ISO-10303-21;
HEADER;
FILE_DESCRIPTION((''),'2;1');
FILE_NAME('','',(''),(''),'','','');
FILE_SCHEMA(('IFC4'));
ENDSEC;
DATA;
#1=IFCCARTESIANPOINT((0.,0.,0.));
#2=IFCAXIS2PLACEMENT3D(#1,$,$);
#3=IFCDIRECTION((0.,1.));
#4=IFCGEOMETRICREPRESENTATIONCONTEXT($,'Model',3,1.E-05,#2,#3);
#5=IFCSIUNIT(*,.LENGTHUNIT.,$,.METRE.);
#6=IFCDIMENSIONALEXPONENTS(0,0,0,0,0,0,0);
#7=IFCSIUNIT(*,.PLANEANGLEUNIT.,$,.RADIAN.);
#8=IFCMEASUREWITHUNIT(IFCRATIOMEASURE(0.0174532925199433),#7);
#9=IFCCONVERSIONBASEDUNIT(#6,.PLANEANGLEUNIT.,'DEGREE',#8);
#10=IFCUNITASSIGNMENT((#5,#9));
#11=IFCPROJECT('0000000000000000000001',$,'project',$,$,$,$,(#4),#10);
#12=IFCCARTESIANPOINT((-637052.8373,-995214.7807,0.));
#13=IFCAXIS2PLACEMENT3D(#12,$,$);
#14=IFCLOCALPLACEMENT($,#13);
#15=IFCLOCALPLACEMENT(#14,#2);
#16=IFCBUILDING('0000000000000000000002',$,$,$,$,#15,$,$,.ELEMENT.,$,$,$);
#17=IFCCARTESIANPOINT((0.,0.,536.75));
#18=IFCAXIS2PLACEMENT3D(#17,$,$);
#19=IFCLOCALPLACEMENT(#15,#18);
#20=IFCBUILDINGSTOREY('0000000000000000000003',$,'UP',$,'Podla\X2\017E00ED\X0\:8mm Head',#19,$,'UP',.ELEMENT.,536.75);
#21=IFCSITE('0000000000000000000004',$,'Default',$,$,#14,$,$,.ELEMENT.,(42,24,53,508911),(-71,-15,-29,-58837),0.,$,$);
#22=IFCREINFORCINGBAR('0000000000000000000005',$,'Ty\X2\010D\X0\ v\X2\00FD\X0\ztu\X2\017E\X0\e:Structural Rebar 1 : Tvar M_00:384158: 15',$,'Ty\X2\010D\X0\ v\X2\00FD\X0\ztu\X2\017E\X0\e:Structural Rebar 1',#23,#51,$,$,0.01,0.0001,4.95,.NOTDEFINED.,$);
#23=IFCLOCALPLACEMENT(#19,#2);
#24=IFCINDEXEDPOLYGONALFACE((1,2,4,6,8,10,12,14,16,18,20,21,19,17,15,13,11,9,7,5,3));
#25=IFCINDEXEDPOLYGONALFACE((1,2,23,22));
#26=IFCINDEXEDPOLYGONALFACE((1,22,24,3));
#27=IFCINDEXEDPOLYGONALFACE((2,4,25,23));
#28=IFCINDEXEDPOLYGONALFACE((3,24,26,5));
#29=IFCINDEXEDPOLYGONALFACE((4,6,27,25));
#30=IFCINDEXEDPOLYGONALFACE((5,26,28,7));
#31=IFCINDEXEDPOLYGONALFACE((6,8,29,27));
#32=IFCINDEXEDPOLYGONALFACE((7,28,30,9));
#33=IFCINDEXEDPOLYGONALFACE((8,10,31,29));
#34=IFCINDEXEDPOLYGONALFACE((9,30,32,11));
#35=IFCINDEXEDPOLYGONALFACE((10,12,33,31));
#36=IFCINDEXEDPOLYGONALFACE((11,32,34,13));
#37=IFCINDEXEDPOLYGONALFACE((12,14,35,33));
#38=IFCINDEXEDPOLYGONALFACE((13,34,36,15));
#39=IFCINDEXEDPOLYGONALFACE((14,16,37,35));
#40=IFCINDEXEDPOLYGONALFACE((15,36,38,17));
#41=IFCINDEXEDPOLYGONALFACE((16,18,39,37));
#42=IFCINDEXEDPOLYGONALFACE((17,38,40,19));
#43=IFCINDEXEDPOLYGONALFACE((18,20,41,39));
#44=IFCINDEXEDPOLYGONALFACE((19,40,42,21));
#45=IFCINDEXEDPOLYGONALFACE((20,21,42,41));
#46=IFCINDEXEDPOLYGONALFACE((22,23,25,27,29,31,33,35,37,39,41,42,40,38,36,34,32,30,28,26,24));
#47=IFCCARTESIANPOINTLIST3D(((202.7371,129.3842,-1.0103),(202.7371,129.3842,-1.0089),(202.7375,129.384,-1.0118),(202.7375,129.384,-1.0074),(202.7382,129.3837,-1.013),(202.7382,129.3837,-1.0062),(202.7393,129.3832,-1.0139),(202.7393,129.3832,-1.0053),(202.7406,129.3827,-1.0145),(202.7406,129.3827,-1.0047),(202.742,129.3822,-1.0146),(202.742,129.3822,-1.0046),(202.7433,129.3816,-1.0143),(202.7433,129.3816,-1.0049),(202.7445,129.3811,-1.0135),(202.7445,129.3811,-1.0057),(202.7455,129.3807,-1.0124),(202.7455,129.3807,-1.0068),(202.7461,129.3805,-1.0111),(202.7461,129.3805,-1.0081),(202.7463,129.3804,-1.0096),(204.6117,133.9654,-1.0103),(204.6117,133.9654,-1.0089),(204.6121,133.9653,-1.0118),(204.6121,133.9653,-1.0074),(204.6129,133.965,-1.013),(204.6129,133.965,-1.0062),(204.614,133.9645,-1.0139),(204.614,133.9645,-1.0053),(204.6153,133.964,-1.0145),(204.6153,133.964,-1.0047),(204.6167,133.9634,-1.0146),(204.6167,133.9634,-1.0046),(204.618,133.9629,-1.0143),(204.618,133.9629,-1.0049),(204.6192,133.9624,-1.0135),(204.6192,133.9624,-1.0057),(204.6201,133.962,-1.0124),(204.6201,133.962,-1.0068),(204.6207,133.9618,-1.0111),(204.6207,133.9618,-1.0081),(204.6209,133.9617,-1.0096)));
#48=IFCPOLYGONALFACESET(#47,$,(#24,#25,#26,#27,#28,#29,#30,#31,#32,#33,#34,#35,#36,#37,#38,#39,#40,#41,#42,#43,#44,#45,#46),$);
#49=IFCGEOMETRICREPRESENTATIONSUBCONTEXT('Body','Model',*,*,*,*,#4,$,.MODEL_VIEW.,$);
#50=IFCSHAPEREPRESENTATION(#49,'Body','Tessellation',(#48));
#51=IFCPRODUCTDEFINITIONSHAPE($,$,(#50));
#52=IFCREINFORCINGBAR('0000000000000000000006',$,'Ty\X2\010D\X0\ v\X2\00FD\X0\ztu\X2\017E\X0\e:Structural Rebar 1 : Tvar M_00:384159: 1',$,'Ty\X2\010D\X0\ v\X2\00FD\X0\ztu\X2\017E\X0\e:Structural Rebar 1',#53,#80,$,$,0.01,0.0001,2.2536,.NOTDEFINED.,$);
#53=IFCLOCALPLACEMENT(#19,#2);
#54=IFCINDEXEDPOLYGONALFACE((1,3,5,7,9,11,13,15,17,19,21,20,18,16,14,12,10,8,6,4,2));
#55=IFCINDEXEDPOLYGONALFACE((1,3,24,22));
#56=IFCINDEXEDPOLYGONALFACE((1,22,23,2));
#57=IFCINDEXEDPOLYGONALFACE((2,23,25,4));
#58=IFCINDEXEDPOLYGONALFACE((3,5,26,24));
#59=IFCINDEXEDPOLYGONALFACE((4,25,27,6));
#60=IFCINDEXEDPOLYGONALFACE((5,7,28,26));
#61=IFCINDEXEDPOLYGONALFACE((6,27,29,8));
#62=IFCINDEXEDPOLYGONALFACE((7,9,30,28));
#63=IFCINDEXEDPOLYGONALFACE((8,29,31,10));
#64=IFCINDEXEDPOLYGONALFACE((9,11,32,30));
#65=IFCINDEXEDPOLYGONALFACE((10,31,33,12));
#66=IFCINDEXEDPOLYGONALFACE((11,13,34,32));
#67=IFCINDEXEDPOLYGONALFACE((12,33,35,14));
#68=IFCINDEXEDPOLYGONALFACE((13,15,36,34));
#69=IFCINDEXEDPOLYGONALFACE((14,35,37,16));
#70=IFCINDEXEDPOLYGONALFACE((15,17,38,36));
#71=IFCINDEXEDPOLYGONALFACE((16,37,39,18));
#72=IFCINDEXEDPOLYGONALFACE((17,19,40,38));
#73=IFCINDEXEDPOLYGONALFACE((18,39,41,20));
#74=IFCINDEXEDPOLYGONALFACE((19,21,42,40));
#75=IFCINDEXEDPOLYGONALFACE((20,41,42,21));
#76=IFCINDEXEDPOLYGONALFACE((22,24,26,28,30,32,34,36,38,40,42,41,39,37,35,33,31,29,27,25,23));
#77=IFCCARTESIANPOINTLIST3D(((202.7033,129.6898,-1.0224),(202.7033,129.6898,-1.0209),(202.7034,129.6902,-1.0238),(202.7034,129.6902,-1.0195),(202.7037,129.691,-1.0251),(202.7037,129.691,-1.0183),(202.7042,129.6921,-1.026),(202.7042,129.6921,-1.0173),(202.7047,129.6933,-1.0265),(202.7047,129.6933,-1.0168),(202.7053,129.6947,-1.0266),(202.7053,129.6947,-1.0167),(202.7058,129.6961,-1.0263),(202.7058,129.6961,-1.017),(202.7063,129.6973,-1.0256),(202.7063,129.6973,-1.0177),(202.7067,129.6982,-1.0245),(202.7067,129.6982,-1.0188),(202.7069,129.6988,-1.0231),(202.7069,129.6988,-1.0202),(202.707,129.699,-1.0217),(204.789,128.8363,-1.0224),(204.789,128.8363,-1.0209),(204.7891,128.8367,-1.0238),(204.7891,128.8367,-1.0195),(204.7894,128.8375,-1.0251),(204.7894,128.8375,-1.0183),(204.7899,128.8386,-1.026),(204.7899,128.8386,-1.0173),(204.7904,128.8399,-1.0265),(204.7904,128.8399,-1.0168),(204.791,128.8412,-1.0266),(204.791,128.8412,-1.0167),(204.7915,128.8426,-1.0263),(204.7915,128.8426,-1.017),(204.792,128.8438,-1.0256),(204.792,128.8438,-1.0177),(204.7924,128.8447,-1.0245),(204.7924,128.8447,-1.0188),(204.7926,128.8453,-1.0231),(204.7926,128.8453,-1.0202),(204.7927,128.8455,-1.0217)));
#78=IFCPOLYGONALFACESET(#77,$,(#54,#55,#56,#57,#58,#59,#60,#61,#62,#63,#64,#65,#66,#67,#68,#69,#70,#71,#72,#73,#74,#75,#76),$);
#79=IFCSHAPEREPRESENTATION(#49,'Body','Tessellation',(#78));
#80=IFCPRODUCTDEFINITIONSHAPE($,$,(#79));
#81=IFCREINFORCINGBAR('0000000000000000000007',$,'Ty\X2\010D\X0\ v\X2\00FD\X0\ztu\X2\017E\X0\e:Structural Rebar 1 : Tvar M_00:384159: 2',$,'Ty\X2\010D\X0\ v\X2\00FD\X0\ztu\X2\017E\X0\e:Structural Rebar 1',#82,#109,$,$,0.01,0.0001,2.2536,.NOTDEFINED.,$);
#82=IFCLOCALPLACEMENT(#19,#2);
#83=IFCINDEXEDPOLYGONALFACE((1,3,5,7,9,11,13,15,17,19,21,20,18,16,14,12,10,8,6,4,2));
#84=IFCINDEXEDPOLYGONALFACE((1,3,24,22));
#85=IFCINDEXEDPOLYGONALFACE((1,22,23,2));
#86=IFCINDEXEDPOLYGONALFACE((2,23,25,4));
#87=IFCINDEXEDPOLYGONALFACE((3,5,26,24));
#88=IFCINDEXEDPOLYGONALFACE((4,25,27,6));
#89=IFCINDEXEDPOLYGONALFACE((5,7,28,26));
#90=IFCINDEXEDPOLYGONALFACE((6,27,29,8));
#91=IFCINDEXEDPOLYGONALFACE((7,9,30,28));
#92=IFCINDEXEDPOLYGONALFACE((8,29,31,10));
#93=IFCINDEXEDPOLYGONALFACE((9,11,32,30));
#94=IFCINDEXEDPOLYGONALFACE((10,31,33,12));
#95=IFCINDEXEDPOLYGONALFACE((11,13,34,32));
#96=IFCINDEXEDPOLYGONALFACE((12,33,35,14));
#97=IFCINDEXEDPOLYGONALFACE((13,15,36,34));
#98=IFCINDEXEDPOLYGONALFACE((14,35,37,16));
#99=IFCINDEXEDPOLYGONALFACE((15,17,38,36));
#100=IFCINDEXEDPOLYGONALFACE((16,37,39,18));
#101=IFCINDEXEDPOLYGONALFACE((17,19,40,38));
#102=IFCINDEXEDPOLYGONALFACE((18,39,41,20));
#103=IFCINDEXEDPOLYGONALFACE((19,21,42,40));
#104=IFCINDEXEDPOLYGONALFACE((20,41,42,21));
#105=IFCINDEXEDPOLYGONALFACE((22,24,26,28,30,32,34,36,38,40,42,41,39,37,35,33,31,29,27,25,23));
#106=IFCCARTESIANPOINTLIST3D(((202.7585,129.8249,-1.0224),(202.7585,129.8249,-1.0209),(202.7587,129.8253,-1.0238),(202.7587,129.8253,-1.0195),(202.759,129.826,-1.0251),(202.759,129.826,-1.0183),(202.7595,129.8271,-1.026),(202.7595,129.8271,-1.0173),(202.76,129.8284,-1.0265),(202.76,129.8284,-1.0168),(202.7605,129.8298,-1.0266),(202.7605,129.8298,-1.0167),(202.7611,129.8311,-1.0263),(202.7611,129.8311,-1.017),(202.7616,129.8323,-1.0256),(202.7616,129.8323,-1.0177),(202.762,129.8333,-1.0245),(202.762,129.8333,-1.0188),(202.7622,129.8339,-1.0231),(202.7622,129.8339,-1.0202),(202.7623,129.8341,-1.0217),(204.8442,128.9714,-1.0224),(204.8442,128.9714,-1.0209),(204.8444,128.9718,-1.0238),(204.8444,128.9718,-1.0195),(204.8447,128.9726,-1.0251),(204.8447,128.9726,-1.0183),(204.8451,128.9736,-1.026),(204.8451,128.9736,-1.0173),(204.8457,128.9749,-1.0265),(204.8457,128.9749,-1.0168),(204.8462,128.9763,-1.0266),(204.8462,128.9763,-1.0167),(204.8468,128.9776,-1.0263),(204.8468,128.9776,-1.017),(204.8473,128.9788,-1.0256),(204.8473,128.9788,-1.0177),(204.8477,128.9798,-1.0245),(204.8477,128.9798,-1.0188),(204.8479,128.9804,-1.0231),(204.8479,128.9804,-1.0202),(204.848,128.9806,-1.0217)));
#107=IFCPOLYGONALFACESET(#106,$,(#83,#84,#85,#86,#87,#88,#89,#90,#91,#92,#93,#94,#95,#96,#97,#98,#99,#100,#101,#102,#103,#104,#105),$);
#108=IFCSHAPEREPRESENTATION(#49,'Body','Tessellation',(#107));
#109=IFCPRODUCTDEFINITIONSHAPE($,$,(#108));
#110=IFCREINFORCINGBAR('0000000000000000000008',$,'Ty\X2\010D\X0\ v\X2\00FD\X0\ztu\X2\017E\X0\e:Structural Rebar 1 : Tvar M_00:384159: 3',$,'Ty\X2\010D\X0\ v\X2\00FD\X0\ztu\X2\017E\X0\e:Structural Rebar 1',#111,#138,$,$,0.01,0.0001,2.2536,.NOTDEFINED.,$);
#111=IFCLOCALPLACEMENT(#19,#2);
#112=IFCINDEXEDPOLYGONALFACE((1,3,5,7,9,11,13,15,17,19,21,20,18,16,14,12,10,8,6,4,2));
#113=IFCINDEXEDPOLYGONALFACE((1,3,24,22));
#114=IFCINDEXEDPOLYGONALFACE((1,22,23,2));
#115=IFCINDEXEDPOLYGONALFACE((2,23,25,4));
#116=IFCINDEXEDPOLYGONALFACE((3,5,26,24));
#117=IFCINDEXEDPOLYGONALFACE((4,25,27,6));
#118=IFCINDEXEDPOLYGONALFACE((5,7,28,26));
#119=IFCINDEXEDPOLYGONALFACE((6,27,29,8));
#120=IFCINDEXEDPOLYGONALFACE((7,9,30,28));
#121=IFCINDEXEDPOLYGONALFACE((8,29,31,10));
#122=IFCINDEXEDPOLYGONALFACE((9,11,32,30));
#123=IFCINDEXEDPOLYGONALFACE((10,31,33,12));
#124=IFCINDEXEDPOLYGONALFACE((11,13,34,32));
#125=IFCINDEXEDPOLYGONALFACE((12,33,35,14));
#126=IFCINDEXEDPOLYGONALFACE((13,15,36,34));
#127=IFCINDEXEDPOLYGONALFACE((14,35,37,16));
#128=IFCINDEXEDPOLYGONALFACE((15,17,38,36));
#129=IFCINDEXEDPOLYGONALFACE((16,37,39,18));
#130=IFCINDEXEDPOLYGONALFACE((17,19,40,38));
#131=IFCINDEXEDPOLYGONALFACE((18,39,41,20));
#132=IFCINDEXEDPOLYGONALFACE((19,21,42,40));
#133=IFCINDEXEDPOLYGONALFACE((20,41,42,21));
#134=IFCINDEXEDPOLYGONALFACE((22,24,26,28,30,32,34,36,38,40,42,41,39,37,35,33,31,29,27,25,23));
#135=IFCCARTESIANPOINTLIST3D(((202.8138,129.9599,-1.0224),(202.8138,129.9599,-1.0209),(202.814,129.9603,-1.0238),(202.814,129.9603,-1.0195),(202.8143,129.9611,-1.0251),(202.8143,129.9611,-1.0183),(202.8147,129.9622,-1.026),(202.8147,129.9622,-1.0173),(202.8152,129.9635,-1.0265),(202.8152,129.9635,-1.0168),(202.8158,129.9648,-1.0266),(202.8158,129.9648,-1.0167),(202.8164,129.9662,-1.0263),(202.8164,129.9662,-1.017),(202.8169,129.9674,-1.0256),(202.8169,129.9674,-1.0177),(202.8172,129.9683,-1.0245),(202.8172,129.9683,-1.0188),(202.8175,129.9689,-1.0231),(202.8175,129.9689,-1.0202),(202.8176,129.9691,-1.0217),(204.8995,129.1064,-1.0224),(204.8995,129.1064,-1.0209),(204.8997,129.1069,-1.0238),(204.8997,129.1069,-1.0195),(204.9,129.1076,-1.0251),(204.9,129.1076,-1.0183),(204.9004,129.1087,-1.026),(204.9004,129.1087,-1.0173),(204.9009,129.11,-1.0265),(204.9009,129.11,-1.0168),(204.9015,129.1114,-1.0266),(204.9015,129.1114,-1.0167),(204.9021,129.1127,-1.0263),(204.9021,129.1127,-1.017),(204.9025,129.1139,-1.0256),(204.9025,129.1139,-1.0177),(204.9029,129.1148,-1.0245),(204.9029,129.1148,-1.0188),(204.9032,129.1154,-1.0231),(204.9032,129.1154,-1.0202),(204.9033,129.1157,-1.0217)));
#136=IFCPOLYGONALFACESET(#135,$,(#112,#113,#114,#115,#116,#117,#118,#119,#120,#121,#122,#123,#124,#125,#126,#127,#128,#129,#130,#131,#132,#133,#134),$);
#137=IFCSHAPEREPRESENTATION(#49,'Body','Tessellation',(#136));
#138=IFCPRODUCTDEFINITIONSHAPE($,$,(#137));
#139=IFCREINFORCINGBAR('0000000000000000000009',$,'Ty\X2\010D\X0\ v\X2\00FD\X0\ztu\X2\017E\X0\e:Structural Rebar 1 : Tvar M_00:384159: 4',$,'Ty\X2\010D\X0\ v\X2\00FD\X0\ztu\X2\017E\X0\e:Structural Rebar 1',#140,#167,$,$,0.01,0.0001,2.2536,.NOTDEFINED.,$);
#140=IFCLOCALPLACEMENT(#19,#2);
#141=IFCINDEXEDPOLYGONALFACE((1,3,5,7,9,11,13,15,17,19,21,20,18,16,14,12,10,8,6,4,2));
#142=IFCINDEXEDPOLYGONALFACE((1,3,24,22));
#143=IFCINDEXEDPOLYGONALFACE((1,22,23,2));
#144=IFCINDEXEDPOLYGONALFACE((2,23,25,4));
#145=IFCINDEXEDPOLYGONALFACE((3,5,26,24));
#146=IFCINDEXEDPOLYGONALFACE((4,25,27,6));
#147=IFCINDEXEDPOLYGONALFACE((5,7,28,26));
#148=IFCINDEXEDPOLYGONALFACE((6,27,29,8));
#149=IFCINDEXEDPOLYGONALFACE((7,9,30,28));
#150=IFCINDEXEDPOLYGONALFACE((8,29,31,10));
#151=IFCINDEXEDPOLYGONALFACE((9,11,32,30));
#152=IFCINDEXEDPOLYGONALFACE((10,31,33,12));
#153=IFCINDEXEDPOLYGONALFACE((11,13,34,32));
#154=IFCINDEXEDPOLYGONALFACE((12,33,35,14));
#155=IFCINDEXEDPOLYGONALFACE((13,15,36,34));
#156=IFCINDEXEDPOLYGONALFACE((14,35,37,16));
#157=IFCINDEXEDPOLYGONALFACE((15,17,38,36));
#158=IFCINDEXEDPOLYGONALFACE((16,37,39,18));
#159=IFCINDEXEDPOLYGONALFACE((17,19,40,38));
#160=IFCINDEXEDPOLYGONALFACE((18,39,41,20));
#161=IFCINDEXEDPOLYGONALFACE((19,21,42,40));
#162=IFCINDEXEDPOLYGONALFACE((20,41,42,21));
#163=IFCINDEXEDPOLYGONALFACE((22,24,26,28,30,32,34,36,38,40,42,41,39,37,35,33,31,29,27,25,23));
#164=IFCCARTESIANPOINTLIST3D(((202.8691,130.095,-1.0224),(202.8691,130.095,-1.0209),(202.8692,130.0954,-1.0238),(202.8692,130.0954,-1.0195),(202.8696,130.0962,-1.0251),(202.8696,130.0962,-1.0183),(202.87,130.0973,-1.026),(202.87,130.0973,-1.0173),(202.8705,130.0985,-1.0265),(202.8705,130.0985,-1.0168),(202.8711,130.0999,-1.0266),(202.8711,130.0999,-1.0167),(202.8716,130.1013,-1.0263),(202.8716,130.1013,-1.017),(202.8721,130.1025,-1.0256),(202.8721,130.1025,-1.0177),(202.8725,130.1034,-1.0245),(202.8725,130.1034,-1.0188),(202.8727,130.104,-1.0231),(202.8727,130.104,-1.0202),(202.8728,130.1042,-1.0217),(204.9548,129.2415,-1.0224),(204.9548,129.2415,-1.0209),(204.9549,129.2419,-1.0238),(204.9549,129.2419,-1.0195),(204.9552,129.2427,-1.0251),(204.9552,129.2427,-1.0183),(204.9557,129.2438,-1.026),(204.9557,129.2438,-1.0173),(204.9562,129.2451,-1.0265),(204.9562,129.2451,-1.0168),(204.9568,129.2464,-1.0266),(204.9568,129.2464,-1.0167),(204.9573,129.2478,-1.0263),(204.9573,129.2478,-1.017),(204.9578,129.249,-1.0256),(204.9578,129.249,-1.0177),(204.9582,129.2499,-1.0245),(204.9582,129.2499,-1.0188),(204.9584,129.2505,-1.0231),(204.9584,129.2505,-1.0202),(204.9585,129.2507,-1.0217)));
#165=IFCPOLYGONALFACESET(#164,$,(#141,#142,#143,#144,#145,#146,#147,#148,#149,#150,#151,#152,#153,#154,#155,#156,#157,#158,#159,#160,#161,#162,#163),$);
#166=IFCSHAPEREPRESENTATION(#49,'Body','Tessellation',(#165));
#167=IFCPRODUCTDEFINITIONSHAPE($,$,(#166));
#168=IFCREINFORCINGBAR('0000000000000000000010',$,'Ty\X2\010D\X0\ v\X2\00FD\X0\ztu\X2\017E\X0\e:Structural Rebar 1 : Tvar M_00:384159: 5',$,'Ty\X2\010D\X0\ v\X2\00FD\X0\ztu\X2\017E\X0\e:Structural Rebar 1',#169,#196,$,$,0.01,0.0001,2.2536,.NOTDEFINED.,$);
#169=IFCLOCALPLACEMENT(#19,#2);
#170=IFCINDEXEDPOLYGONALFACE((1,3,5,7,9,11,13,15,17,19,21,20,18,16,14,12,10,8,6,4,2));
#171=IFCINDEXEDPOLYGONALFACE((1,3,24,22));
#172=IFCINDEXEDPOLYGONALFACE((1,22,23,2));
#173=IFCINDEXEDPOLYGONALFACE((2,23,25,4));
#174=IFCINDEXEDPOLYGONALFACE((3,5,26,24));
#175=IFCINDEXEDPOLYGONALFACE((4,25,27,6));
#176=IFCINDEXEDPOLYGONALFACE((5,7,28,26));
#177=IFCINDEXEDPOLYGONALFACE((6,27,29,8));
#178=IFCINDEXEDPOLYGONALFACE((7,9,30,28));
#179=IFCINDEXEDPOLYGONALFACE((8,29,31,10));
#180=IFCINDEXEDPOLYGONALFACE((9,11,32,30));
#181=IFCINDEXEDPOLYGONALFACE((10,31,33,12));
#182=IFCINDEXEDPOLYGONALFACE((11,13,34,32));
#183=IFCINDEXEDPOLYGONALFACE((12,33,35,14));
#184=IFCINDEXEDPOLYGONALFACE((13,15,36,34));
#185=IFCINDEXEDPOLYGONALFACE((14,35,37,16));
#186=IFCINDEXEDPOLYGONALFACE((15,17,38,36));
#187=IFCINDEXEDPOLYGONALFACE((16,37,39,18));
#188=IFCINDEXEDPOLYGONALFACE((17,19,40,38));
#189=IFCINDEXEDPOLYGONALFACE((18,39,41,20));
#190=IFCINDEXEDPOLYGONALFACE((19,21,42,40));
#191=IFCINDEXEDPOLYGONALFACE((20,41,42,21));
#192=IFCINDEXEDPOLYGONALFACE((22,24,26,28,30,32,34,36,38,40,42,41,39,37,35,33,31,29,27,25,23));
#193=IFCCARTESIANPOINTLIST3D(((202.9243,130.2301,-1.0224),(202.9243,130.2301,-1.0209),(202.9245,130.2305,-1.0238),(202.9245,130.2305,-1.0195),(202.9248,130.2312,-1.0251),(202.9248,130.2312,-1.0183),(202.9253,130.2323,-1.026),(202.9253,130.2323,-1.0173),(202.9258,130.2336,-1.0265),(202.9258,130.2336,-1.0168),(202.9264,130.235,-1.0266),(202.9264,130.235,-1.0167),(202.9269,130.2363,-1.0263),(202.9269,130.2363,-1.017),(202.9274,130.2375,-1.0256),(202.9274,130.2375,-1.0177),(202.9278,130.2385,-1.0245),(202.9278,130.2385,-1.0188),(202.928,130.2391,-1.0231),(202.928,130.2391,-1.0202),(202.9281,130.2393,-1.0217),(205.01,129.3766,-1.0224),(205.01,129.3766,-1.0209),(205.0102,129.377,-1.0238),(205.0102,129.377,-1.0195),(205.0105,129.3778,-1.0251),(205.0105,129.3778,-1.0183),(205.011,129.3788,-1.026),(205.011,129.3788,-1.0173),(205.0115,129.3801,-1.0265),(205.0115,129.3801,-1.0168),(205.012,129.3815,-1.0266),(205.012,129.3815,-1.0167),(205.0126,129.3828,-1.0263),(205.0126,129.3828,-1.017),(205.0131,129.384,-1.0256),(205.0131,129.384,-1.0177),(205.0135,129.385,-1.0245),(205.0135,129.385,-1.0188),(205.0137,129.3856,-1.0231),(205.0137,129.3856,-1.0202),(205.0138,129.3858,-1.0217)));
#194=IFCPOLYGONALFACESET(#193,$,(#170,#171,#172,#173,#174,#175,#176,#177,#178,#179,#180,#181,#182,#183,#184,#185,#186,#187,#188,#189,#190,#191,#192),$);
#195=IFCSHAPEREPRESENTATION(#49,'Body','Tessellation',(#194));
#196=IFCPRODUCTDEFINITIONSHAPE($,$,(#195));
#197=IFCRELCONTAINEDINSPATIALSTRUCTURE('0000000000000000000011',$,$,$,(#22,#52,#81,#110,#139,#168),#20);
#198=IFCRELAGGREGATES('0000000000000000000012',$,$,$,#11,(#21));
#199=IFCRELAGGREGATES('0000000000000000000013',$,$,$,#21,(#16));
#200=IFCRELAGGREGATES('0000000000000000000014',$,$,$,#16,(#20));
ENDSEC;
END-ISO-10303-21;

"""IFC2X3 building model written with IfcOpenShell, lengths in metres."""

from ifc_helpers import new_model, entity, si_unit, converted_unit, direction, frame, origin, place, context, subcontext, project, spatial, element, save


model = new_model("IFC2X3")

# Units and contexts
model_context = context("Model", 3, precision=1e-05, world=origin(), true_north=direction((0.0, 1.0)))
body_context = subcontext(model_context, "Body", "Model", "MODEL_VIEW")
ifc_project = project(units=[si_unit("LENGTHUNIT", "METRE"), converted_unit("PLANEANGLEUNIT", "DEGREE", entity("IfcRatioMeasure", 0.0174532925199433), si_unit("PLANEANGLEUNIT", "RADIAN"), dimensions=[0, 0, 0, 0, 0, 0, 0])], contexts=[model_context])

# Site, building, storey
site_placement = place(None, frame((-637052.8373, -995214.7807, 0.0)))
site = spatial("IfcSite", under=ifc_project, at=site_placement, Name="Default", CompositionType="ELEMENT", RefLatitude=(42, 24, 53, 508911), RefLongitude=(-71, -15, -29, -58837), RefElevation=0.0)
building_placement = place(site_placement, origin())
building = spatial("IfcBuilding", under=site, at=building_placement, CompositionType="ELEMENT")
storey_placement = place(building_placement, frame((0.0, 0.0, 536.75)))
storey = spatial("IfcBuildingStorey", under=building, at=storey_placement, Name="UP", ObjectType="Podlaží:8mm Head", LongName="UP", CompositionType="ELEMENT", Elevation=536.75)

# Reinforcing bars
reinforcing_bar_1_placement = place(storey_placement, origin())
element("IfcReinforcingBar", 1, at=reinforcing_bar_1_placement, inside=storey, Name="Tyč výztuže:Structural Rebar 1 : Tvar M_00:384158: 15", ObjectType="Tyč výztuže:Structural Rebar 1", BarLength=4.95, BarRole="NOTDEFINED", CrossSectionArea=0.0001, NominalDiameter=0.01, context=body_context, shape_type="AdvancedSweptSolid", body=[
    entity("IfcSweptDiskSolid", entity("IfcCompositeCurve", [entity("IfcCompositeCurveSegment", "CONTINUOUS", True, entity("IfcPolyline", [entity("IfcCartesianPoint", [-204.6163, -133.9636, 1.0096]), entity("IfcCartesianPoint", [-202.7416, -129.3823, 1.0096])]))], False), 0.005, None, 0.0, 1.0),
])
reinforcing_bar_2_placement = place(storey_placement, origin())
element("IfcReinforcingBar", 2, at=reinforcing_bar_2_placement, inside=storey, Name="Tyč výztuže:Structural Rebar 1 : Tvar M_00:384159: 1", ObjectType="Tyč výztuže:Structural Rebar 1", BarLength=2.2536, BarRole="NOTDEFINED", CrossSectionArea=0.0001, NominalDiameter=0.01, context=body_context, shape_type="AdvancedSweptSolid", body=[
    entity("IfcSweptDiskSolid", entity("IfcCompositeCurve", [entity("IfcCompositeCurveSegment", "CONTINUOUS", True, entity("IfcPolyline", [entity("IfcCartesianPoint", [-204.7908, -128.8409, 1.0217]), entity("IfcCartesianPoint", [-202.7051, -129.6944, 1.0217])]))], False), 0.005, None, 0.0, 1.0),
])
reinforcing_bar_3_placement = place(storey_placement, origin())
element("IfcReinforcingBar", 3, at=reinforcing_bar_3_placement, inside=storey, Name="Tyč výztuže:Structural Rebar 1 : Tvar M_00:384159: 2", ObjectType="Tyč výztuže:Structural Rebar 1", BarLength=2.2536, BarRole="NOTDEFINED", CrossSectionArea=0.0001, NominalDiameter=0.01, context=body_context, shape_type="AdvancedSweptSolid", body=[
    entity("IfcSweptDiskSolid", entity("IfcCompositeCurve", [entity("IfcCompositeCurveSegment", "CONTINUOUS", True, entity("IfcPolyline", [entity("IfcCartesianPoint", [-204.8461, -128.976, 1.0217]), entity("IfcCartesianPoint", [-202.7604, -129.8294, 1.0217])]))], False), 0.005, None, 0.0, 1.0),
])
reinforcing_bar_4_placement = place(storey_placement, origin())
element("IfcReinforcingBar", 4, at=reinforcing_bar_4_placement, inside=storey, Name="Tyč výztuže:Structural Rebar 1 : Tvar M_00:384159: 3", ObjectType="Tyč výztuže:Structural Rebar 1", BarLength=2.2536, BarRole="NOTDEFINED", CrossSectionArea=0.0001, NominalDiameter=0.01, context=body_context, shape_type="AdvancedSweptSolid", body=[
    entity("IfcSweptDiskSolid", entity("IfcCompositeCurve", [entity("IfcCompositeCurveSegment", "CONTINUOUS", True, entity("IfcPolyline", [entity("IfcCartesianPoint", [-204.9014, -129.111, 1.0217]), entity("IfcCartesianPoint", [-202.8157, -129.9645, 1.0217])]))], False), 0.005, None, 0.0, 1.0),
])
reinforcing_bar_5_placement = place(storey_placement, origin())
element("IfcReinforcingBar", 5, at=reinforcing_bar_5_placement, inside=storey, Name="Tyč výztuže:Structural Rebar 1 : Tvar M_00:384159: 4", ObjectType="Tyč výztuže:Structural Rebar 1", BarLength=2.2536, BarRole="NOTDEFINED", CrossSectionArea=0.0001, NominalDiameter=0.01, context=body_context, shape_type="AdvancedSweptSolid", body=[
    entity("IfcSweptDiskSolid", entity("IfcCompositeCurve", [entity("IfcCompositeCurveSegment", "CONTINUOUS", True, entity("IfcPolyline", [entity("IfcCartesianPoint", [-204.9566, -129.2461, 1.0217]), entity("IfcCartesianPoint", [-202.8709, -130.0996, 1.0217])]))], False), 0.005, None, 0.0, 1.0),
])
reinforcing_bar_6_placement = place(storey_placement, origin())
element("IfcReinforcingBar", 6, at=reinforcing_bar_6_placement, inside=storey, Name="Tyč výztuže:Structural Rebar 1 : Tvar M_00:384159: 5", ObjectType="Tyč výztuže:Structural Rebar 1", BarLength=2.2536, BarRole="NOTDEFINED", CrossSectionArea=0.0001, NominalDiameter=0.01, context=body_context, shape_type="AdvancedSweptSolid", body=[
    entity("IfcSweptDiskSolid", entity("IfcCompositeCurve", [entity("IfcCompositeCurveSegment", "CONTINUOUS", True, entity("IfcPolyline", [entity("IfcCartesianPoint", [-205.0119, -129.3812, 1.0217]), entity("IfcCartesianPoint", [-202.9262, -130.2346, 1.0217])]))], False), 0.005, None, 0.0, 1.0),
])

save(model, "model.ifc")
